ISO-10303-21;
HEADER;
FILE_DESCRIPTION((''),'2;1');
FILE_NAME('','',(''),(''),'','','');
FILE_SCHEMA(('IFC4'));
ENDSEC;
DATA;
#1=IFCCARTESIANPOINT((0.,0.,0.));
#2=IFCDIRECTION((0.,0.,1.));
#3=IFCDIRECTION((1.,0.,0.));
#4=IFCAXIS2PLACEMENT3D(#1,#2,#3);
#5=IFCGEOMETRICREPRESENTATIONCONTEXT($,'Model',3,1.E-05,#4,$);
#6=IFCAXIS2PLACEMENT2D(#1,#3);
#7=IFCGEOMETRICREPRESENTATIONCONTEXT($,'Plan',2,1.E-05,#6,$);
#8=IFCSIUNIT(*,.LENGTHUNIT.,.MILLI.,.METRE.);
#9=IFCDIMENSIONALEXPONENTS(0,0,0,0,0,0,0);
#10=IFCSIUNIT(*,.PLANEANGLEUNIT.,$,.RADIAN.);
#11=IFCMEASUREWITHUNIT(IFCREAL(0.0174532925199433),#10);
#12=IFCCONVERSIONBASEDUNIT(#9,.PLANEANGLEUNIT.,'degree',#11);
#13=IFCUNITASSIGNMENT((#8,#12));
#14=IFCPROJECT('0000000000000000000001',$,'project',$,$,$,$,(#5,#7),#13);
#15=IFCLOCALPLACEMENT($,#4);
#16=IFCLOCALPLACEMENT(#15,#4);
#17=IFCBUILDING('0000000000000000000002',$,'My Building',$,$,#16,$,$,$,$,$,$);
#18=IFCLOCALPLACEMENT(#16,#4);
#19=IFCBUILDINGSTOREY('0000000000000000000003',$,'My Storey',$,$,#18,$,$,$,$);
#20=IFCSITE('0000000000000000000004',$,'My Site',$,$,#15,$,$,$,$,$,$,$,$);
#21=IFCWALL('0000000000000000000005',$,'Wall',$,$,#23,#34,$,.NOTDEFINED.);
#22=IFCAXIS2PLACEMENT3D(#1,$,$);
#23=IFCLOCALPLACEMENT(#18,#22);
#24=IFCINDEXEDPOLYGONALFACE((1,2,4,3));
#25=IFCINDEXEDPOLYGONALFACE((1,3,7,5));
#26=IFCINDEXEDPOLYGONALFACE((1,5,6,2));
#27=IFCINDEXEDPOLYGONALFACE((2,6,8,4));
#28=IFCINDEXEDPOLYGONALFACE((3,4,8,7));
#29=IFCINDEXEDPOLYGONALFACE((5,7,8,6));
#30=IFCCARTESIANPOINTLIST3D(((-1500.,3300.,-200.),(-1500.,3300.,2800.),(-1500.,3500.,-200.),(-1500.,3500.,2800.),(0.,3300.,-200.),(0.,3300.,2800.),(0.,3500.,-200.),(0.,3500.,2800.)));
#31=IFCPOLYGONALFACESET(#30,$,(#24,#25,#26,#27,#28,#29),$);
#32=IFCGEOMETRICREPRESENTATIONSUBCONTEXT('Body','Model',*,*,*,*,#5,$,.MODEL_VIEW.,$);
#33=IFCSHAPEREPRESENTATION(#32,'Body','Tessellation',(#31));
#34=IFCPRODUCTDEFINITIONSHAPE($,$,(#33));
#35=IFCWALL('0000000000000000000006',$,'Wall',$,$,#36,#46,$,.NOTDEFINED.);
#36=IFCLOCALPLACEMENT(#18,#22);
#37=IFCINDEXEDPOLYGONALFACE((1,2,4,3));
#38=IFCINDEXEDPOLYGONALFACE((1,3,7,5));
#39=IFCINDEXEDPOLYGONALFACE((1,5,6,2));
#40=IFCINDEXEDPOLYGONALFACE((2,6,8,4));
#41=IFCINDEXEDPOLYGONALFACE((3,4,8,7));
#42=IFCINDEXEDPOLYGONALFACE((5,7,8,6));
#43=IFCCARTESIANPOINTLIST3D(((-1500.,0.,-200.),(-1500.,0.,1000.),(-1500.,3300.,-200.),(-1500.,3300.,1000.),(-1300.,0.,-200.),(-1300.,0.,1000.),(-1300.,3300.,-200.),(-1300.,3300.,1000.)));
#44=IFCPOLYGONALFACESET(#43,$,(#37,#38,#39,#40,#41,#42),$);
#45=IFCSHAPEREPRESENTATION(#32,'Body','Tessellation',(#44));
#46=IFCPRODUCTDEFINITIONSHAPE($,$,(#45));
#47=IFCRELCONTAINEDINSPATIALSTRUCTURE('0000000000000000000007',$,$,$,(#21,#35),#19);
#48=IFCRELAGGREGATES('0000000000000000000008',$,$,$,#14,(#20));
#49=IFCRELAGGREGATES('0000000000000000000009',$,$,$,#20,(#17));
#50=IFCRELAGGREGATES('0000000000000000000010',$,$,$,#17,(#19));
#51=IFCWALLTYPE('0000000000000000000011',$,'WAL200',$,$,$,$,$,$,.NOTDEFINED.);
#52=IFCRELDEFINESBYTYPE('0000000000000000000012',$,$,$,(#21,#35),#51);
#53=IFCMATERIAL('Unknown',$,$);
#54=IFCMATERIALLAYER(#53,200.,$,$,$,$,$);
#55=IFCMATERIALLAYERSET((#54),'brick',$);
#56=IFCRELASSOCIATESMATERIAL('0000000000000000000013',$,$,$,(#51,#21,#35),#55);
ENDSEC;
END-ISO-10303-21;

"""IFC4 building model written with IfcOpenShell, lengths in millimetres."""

from ifc_helpers import new_model, entity, si_unit, converted_unit, frame, frame_2d, origin_with_axes, place, context, subcontext, project, spatial, indexed_curve, outline, extrude, material, layer, layer_set, layer_usage, type_object, element, save


model = new_model("IFC4")

# Units and contexts
model_context = context("Model", 3, precision=1e-05, world=origin_with_axes())
plan_context = context("Plan", 2, precision=1e-05, world=frame_2d((0.0, 0.0, 0.0), x_axis=(1.0, 0.0, 0.0)))
body_context = subcontext(model_context, "Body", "Model", "MODEL_VIEW")
ifc_project = project(units=[si_unit("LENGTHUNIT", "METRE", prefix="MILLI"), converted_unit("PLANEANGLEUNIT", "degree", entity("IfcReal", 0.0174532925199433), si_unit("PLANEANGLEUNIT", "RADIAN"), dimensions=[0, 0, 0, 0, 0, 0, 0])], contexts=[model_context, plan_context])

# Site, building, storey
site_placement = place(None, origin_with_axes())
site = spatial("IfcSite", under=ifc_project, at=site_placement, Name="My Site")
building_placement = place(site_placement, origin_with_axes())
building = spatial("IfcBuilding", under=site, at=building_placement, Name="My Building")
storey_placement = place(building_placement, origin_with_axes())
storey = spatial("IfcBuildingStorey", under=building, at=storey_placement, Name="My Storey")

# Shared definitions
ifc_material = material(Name="Unknown")

# Shared definitions
ifc_layer_1 = layer(ifc_material, 200.0)
ifc_layer_set_1 = layer_set([ifc_layer_1], Name="brick")
wall_type_1 = type_object("IfcWallType", Name="WAL200", PredefinedType="NOTDEFINED", material=ifc_layer_set_1)

# Walls
ifc_layer_usage_1 = layer_usage(ifc_layer_set_1, "AXIS2", "POSITIVE", 0.0)
wall_1_placement = place(storey_placement, frame((0.0, 3500.0, -200.0), z_axis=(0.0, 0.0, 1.0), x_axis=(-1.0, 0.0, 0.0)))
element("IfcWall", 1, at=wall_1_placement, inside=storey, type_object=wall_type_1, material=ifc_layer_usage_1, Name="Wall", PredefinedType="NOTDEFINED", context=body_context, shape_type="SweptSolid", body=[
    extrude(outline(indexed_curve([(0.0, 0.0), (0.0, 200.0), (1500.0, 200.0), (1500.0, 0.0), (0.0, 0.0)], self_intersect=False)), origin_with_axes(), (0.0, 0.0, 1.0), 3000.0),
])
ifc_layer_usage_2 = layer_usage(ifc_layer_set_1, "AXIS2", "POSITIVE", 0.0)
wall_2_placement = place(storey_placement, frame((-1500.0, 3300.0, -200.0), z_axis=(0.0, 0.0, 1.0), x_axis=(0.0, -1.0, 0.0)))
element("IfcWall", 2, at=wall_2_placement, inside=storey, type_object=wall_type_1, material=ifc_layer_usage_2, Name="Wall", PredefinedType="NOTDEFINED", context=body_context, shape_type="SweptSolid", body=[
    extrude(outline(indexed_curve([(0.0, 0.0), (0.0, 200.0), (3300.0, 200.0), (3300.0, 0.0), (0.0, 0.0)], self_intersect=False)), origin_with_axes(), (0.0, 0.0, 1.0), 1200.0),
])

save(model, "model.ifc")
